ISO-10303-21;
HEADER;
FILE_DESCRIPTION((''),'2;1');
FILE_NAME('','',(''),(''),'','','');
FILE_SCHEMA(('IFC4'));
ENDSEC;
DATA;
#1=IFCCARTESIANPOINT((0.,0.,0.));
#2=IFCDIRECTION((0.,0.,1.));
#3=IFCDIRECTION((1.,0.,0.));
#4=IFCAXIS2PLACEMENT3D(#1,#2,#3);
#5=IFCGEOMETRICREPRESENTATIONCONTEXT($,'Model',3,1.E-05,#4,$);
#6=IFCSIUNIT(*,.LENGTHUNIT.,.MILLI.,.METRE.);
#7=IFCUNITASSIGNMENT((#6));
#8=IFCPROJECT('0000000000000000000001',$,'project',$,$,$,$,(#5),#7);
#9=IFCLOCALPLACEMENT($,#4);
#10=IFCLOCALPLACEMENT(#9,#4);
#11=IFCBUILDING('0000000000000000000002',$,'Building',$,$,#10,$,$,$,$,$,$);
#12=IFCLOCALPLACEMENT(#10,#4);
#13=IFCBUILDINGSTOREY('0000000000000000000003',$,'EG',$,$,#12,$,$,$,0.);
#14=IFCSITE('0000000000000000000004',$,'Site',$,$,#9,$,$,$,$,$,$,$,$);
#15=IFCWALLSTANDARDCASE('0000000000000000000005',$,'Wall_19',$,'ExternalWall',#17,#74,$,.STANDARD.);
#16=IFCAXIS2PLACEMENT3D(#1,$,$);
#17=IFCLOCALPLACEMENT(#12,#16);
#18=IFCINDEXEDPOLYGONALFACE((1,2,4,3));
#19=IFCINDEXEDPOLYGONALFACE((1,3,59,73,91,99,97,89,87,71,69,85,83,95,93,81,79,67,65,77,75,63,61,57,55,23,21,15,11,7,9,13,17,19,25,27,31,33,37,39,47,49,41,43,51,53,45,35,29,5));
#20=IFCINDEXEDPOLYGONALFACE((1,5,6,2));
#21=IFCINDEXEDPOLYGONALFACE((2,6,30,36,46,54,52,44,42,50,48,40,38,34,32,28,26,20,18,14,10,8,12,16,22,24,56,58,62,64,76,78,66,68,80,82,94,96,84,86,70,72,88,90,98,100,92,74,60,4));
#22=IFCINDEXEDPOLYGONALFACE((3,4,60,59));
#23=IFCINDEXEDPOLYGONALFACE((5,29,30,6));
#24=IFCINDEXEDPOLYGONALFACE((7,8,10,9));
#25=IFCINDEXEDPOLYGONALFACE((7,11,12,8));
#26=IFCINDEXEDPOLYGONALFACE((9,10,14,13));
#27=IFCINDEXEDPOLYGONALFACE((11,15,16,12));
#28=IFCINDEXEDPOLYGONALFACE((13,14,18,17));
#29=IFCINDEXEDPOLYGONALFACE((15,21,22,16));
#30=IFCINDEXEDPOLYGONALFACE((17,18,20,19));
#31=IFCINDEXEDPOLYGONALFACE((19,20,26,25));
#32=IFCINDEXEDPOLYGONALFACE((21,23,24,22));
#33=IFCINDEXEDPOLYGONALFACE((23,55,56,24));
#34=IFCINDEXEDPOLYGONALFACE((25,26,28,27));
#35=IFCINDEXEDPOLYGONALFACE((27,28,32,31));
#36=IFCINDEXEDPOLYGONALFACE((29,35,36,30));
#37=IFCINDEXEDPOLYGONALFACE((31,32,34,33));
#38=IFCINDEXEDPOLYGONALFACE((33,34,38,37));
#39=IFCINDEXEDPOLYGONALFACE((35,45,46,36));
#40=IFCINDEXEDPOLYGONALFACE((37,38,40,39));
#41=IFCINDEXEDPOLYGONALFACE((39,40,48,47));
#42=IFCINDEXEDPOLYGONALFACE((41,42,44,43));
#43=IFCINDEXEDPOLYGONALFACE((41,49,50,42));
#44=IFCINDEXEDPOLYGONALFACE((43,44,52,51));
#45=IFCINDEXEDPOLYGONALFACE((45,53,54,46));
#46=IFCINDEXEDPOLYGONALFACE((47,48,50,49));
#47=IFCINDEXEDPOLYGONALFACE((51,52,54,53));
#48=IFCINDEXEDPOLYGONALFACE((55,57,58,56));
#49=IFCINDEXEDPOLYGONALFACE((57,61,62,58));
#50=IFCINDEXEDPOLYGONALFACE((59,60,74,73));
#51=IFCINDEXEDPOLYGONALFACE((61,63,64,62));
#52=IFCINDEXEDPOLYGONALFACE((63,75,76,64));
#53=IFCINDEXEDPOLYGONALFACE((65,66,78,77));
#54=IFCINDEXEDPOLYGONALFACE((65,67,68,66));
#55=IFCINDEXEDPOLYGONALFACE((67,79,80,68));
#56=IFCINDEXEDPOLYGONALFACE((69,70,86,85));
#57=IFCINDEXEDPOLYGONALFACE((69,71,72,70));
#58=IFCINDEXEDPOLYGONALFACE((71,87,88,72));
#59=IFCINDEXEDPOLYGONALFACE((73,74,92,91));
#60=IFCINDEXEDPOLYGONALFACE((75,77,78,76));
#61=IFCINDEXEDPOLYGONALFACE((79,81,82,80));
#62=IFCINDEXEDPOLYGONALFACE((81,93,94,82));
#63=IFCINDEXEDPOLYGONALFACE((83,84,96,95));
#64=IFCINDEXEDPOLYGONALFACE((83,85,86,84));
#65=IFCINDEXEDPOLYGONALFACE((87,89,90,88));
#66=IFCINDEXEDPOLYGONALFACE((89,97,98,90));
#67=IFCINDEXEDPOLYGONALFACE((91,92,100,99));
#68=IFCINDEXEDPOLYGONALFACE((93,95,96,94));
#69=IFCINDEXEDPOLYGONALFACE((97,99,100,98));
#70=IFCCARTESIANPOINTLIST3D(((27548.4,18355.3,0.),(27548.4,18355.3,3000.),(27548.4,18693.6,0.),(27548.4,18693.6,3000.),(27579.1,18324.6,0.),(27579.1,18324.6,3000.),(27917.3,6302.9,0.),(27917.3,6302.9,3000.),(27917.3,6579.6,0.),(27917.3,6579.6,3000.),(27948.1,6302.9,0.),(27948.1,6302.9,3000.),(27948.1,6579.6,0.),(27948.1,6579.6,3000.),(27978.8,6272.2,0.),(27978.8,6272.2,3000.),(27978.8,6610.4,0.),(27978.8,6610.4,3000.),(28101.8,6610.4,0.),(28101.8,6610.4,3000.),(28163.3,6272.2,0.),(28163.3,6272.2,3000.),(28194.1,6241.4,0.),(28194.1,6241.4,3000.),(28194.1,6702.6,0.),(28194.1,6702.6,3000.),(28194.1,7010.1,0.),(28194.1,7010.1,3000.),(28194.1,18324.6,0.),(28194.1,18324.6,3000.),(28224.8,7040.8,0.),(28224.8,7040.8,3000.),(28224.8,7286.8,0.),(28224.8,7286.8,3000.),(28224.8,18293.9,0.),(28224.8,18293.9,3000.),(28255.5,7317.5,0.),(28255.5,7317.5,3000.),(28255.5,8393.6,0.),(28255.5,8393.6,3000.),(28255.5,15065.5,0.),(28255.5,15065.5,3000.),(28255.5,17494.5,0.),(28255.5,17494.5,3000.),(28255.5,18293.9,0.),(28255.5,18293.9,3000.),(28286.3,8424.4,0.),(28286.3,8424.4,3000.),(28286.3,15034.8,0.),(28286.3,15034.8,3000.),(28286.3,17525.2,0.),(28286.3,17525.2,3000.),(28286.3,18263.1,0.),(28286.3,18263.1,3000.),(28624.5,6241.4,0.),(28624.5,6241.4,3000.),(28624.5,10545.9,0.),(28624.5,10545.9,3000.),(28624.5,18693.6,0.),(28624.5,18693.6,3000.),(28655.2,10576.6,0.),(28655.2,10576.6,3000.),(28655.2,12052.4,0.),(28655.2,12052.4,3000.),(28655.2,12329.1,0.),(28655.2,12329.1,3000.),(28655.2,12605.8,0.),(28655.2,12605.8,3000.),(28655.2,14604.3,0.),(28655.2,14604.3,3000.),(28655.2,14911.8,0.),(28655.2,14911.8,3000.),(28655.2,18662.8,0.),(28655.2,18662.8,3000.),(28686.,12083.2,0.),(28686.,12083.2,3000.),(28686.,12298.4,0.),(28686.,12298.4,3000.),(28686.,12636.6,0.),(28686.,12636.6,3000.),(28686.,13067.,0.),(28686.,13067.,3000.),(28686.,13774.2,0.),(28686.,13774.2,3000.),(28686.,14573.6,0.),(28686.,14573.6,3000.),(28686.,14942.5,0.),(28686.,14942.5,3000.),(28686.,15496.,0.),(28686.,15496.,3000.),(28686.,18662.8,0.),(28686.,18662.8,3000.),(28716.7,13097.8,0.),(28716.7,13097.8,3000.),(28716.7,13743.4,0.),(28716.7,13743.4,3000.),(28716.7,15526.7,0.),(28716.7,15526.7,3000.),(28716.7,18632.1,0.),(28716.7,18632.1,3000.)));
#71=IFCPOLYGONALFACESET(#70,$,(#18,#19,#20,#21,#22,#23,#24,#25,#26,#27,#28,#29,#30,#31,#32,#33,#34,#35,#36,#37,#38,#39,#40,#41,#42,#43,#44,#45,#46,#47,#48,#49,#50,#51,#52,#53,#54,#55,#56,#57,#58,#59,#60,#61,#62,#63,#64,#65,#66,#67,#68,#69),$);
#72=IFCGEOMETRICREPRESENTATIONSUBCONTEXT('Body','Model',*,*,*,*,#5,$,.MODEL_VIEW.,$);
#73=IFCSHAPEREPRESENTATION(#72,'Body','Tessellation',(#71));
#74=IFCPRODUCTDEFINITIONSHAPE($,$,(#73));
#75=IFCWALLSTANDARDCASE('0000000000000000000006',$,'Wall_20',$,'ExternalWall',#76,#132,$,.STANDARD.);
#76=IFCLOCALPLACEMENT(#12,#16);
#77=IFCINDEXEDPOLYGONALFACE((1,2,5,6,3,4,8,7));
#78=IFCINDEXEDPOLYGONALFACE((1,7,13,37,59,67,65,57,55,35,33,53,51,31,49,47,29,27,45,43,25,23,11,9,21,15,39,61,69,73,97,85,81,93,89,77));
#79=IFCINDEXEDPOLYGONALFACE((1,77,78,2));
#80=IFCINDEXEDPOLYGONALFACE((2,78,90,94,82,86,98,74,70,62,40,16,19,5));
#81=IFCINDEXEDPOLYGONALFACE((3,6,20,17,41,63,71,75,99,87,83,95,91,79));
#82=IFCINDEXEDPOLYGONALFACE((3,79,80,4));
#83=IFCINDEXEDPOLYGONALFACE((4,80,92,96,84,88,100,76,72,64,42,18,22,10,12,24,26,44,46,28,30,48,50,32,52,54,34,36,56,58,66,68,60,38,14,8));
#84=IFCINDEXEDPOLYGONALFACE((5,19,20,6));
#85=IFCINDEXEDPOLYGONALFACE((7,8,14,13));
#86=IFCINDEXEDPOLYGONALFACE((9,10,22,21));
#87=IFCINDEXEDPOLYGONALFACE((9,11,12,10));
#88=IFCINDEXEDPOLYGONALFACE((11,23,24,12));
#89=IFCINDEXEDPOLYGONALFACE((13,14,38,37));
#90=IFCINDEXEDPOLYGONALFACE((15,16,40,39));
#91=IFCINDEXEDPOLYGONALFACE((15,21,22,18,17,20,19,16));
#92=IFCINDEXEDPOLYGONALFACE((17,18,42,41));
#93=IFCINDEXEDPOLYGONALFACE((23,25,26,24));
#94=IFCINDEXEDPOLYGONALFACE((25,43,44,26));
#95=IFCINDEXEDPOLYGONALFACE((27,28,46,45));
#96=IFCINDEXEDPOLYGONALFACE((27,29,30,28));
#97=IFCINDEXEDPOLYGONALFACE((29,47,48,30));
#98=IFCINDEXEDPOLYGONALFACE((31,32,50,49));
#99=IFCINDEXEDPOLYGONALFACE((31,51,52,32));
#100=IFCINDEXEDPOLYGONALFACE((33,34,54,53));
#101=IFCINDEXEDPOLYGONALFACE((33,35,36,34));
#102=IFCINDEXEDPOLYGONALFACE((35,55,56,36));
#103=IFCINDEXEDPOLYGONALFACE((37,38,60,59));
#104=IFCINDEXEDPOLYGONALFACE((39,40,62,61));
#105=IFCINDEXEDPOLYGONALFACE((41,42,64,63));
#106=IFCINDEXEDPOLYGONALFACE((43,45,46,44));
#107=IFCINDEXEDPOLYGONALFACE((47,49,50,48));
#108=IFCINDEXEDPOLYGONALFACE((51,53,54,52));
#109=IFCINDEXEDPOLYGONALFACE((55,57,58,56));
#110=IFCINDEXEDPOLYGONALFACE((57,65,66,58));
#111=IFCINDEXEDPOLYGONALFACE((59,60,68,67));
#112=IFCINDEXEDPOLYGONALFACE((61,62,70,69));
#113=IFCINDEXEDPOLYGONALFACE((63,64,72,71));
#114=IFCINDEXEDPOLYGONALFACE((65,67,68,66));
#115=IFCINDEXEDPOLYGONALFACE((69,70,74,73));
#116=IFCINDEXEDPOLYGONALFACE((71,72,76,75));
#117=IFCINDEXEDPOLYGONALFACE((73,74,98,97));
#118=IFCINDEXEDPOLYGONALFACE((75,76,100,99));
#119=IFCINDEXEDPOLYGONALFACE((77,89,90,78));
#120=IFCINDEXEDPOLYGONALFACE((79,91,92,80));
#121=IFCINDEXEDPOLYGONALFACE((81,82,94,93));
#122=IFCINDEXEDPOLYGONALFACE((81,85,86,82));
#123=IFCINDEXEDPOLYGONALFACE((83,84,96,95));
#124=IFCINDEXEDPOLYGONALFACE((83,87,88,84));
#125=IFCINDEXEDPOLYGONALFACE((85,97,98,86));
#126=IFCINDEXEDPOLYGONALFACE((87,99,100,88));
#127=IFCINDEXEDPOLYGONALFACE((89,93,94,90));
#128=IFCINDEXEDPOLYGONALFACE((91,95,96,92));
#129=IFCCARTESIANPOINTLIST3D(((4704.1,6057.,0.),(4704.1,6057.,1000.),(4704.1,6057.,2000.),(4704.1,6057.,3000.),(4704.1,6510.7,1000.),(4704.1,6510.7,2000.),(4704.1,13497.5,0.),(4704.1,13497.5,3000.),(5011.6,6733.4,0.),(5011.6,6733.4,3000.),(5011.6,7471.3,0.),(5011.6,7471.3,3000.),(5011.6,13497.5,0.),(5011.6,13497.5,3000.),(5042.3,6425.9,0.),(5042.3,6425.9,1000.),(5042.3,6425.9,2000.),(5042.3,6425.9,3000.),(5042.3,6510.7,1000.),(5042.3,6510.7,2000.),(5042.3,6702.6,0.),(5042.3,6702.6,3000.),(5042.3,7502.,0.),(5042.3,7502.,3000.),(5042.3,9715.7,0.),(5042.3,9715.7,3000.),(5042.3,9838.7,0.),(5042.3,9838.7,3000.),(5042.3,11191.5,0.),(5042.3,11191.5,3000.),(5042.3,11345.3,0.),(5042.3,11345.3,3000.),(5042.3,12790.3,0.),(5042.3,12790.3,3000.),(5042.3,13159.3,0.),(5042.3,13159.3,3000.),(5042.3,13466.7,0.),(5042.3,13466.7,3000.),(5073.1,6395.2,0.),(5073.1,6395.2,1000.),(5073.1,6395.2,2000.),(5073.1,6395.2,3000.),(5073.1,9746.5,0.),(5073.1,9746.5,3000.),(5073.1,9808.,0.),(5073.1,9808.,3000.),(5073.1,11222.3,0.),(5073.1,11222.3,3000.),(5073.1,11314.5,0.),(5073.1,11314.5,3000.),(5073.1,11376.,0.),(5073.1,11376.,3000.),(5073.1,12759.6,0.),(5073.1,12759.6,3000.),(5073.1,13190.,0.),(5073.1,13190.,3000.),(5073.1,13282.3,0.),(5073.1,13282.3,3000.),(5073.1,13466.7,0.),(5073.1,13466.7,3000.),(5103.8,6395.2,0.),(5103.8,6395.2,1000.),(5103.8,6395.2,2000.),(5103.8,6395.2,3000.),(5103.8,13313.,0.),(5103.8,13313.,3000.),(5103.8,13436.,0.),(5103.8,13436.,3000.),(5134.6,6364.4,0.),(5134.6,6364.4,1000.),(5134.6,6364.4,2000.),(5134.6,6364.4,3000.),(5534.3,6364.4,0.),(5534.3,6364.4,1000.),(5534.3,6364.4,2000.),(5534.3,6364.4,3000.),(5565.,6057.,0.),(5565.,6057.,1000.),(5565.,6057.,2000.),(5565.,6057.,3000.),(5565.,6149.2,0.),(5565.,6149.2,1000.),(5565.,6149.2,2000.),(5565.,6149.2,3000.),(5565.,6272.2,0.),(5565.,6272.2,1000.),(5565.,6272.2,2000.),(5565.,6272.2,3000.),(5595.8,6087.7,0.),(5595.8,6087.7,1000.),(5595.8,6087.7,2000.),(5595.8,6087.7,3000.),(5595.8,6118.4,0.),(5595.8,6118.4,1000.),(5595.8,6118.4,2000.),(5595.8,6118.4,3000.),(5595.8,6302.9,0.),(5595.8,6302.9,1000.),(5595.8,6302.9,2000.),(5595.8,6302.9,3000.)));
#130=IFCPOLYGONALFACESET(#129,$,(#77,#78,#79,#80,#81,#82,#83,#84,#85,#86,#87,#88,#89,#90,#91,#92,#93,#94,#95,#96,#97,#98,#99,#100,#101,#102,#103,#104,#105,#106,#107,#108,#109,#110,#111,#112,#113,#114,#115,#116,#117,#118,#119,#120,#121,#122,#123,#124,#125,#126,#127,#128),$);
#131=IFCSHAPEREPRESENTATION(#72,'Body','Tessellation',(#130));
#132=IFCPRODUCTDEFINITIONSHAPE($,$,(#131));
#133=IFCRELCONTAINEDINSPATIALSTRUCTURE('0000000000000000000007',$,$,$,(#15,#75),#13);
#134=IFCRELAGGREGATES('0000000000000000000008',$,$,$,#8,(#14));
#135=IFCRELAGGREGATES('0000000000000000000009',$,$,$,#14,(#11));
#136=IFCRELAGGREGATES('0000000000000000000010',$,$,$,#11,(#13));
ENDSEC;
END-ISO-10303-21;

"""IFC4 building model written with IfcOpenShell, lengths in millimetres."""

from ifc_helpers import new_model, si_unit, frame, origin_with_axes, place, context, subcontext, project, spatial, polyline, rectangle, outline, extrude, element, save


model = new_model("IFC4")

# Units and contexts
model_context = context("Model", 3, precision=1e-05, world=origin_with_axes())
body_context = subcontext(model_context, "Body", "Model", "MODEL_VIEW")
ifc_project = project(units=[si_unit("LENGTHUNIT", "METRE", prefix="MILLI")], contexts=[model_context])

# Site, building, storey
site_placement = place(None, origin_with_axes())
site = spatial("IfcSite", under=ifc_project, at=site_placement, Name="Site")
building_placement = place(site_placement, origin_with_axes())
building = spatial("IfcBuilding", under=site, at=building_placement, Name="Building")
storey_placement = place(building_placement, origin_with_axes())
storey = spatial("IfcBuildingStorey", under=building, at=storey_placement, Name="EG", Elevation=0.0)

# Wall
wall_1_placement = place(storey_placement, origin_with_axes())
element("IfcWallStandardCase", 1, at=wall_1_placement, inside=storey, Name="Wall_19", ObjectType="ExternalWall", PredefinedType="STANDARD", context=body_context, shape_type="SweptSolid", body=[
    extrude(outline(polyline([(28194.1, 6241.4, 0.0), (28163.3, 6272.2, 0.0), (27978.8, 6272.2, 0.0), (27948.1, 6302.9, 0.0), (27917.3, 6302.9, 0.0), (27917.3, 6579.6, 0.0), (27948.1, 6579.6, 0.0), (27978.8, 6610.4, 0.0), (28101.8, 6610.4, 0.0), (28194.1, 6702.6, 0.0), (28194.1, 7010.1, 0.0), (28224.8, 7040.8, 0.0), (28224.8, 7286.8, 0.0), (28255.5, 7317.5, 0.0), (28255.5, 8393.6, 0.0), (28286.3, 8424.4, 0.0), (28286.3, 15034.8, 0.0), (28255.5, 15065.5, 0.0), (28255.5, 17494.5, 0.0), (28286.3, 17525.2, 0.0), (28286.3, 18263.1, 0.0), (28255.5, 18293.9, 0.0), (28224.8, 18293.9, 0.0), (28194.1, 18324.6, 0.0), (27579.1, 18324.6, 0.0), (27548.4, 18355.3, 0.0), (27548.4, 18693.6, 0.0), (28624.5, 18693.6, 0.0), (28655.2, 18662.8, 0.0), (28686.0, 18662.8, 0.0), (28716.7, 18632.1, 0.0), (28716.7, 15526.7, 0.0), (28686.0, 15496.0, 0.0), (28686.0, 14942.5, 0.0), (28655.2, 14911.8, 0.0), (28655.2, 14604.3, 0.0), (28686.0, 14573.6, 0.0), (28686.0, 13774.2, 0.0), (28716.7, 13743.4, 0.0), (28716.7, 13097.8, 0.0), (28686.0, 13067.0, 0.0), (28686.0, 12636.6, 0.0), (28655.2, 12605.8, 0.0), (28655.2, 12329.1, 0.0), (28686.0, 12298.4, 0.0), (28686.0, 12083.2, 0.0), (28655.2, 12052.4, 0.0), (28655.2, 10576.6, 0.0), (28624.5, 10545.9, 0.0), (28624.5, 6241.4, 0.0), (28194.1, 6241.4, 0.0)])), origin_with_axes(), (0.0, 0.0, 1.0), 3000.0),
])

# Wall, opening
wall_2_placement = place(storey_placement, origin_with_axes())
wall_2 = element("IfcWallStandardCase", 2, at=wall_2_placement, inside=storey, Name="Wall_20", ObjectType="ExternalWall", PredefinedType="STANDARD", context=body_context, shape_type="SweptSolid", body=[
    extrude(outline(polyline([(4704.1, 6057.0, 0.0), (4704.1, 13497.5, 0.0), (5011.6, 13497.5, 0.0), (5042.3, 13466.7, 0.0), (5073.1, 13466.7, 0.0), (5103.8, 13436.0, 0.0), (5103.8, 13313.0, 0.0), (5073.1, 13282.3, 0.0), (5073.1, 13190.0, 0.0), (5042.3, 13159.3, 0.0), (5042.3, 12790.3, 0.0), (5073.1, 12759.6, 0.0), (5073.1, 11376.0, 0.0), (5042.3, 11345.3, 0.0), (5073.1, 11314.5, 0.0), (5073.1, 11222.3, 0.0), (5042.3, 11191.5, 0.0), (5042.3, 9838.7, 0.0), (5073.1, 9808.0, 0.0), (5073.1, 9746.5, 0.0), (5042.3, 9715.7, 0.0), (5042.3, 7502.0, 0.0), (5011.6, 7471.3, 0.0), (5011.6, 6733.4, 0.0), (5042.3, 6702.6, 0.0), (5042.3, 6425.9, 0.0), (5073.1, 6395.2, 0.0), (5103.8, 6395.2, 0.0), (5134.6, 6364.4, 0.0), (5534.3, 6364.4, 0.0), (5595.8, 6302.9, 0.0), (5565.0, 6272.2, 0.0), (5565.0, 6149.2, 0.0), (5595.8, 6118.4, 0.0), (5595.8, 6087.7, 0.0), (5565.0, 6057.0, 0.0), (4704.1, 6057.0, 0.0)])), origin_with_axes(), (0.0, 0.0, 1.0), 3000.0),
])
opening_1_placement = place(wall_2_placement, origin_with_axes())
element("IfcOpeningElement", 3, at=opening_1_placement, inside=storey, cuts=wall_2, context=body_context, shape_type="SweptSolid", body=[
    extrude(rectangle(XDim=600.0, YDim=891.6), frame((5150.0, 6210.7, 1000.0), z_axis=(0.0, 0.0, 1.0), x_axis=(0.0, 1.0, 0.0)), (0.0, 0.0, 1.0), 1000.0),
])

save(model, "model.ifc")
